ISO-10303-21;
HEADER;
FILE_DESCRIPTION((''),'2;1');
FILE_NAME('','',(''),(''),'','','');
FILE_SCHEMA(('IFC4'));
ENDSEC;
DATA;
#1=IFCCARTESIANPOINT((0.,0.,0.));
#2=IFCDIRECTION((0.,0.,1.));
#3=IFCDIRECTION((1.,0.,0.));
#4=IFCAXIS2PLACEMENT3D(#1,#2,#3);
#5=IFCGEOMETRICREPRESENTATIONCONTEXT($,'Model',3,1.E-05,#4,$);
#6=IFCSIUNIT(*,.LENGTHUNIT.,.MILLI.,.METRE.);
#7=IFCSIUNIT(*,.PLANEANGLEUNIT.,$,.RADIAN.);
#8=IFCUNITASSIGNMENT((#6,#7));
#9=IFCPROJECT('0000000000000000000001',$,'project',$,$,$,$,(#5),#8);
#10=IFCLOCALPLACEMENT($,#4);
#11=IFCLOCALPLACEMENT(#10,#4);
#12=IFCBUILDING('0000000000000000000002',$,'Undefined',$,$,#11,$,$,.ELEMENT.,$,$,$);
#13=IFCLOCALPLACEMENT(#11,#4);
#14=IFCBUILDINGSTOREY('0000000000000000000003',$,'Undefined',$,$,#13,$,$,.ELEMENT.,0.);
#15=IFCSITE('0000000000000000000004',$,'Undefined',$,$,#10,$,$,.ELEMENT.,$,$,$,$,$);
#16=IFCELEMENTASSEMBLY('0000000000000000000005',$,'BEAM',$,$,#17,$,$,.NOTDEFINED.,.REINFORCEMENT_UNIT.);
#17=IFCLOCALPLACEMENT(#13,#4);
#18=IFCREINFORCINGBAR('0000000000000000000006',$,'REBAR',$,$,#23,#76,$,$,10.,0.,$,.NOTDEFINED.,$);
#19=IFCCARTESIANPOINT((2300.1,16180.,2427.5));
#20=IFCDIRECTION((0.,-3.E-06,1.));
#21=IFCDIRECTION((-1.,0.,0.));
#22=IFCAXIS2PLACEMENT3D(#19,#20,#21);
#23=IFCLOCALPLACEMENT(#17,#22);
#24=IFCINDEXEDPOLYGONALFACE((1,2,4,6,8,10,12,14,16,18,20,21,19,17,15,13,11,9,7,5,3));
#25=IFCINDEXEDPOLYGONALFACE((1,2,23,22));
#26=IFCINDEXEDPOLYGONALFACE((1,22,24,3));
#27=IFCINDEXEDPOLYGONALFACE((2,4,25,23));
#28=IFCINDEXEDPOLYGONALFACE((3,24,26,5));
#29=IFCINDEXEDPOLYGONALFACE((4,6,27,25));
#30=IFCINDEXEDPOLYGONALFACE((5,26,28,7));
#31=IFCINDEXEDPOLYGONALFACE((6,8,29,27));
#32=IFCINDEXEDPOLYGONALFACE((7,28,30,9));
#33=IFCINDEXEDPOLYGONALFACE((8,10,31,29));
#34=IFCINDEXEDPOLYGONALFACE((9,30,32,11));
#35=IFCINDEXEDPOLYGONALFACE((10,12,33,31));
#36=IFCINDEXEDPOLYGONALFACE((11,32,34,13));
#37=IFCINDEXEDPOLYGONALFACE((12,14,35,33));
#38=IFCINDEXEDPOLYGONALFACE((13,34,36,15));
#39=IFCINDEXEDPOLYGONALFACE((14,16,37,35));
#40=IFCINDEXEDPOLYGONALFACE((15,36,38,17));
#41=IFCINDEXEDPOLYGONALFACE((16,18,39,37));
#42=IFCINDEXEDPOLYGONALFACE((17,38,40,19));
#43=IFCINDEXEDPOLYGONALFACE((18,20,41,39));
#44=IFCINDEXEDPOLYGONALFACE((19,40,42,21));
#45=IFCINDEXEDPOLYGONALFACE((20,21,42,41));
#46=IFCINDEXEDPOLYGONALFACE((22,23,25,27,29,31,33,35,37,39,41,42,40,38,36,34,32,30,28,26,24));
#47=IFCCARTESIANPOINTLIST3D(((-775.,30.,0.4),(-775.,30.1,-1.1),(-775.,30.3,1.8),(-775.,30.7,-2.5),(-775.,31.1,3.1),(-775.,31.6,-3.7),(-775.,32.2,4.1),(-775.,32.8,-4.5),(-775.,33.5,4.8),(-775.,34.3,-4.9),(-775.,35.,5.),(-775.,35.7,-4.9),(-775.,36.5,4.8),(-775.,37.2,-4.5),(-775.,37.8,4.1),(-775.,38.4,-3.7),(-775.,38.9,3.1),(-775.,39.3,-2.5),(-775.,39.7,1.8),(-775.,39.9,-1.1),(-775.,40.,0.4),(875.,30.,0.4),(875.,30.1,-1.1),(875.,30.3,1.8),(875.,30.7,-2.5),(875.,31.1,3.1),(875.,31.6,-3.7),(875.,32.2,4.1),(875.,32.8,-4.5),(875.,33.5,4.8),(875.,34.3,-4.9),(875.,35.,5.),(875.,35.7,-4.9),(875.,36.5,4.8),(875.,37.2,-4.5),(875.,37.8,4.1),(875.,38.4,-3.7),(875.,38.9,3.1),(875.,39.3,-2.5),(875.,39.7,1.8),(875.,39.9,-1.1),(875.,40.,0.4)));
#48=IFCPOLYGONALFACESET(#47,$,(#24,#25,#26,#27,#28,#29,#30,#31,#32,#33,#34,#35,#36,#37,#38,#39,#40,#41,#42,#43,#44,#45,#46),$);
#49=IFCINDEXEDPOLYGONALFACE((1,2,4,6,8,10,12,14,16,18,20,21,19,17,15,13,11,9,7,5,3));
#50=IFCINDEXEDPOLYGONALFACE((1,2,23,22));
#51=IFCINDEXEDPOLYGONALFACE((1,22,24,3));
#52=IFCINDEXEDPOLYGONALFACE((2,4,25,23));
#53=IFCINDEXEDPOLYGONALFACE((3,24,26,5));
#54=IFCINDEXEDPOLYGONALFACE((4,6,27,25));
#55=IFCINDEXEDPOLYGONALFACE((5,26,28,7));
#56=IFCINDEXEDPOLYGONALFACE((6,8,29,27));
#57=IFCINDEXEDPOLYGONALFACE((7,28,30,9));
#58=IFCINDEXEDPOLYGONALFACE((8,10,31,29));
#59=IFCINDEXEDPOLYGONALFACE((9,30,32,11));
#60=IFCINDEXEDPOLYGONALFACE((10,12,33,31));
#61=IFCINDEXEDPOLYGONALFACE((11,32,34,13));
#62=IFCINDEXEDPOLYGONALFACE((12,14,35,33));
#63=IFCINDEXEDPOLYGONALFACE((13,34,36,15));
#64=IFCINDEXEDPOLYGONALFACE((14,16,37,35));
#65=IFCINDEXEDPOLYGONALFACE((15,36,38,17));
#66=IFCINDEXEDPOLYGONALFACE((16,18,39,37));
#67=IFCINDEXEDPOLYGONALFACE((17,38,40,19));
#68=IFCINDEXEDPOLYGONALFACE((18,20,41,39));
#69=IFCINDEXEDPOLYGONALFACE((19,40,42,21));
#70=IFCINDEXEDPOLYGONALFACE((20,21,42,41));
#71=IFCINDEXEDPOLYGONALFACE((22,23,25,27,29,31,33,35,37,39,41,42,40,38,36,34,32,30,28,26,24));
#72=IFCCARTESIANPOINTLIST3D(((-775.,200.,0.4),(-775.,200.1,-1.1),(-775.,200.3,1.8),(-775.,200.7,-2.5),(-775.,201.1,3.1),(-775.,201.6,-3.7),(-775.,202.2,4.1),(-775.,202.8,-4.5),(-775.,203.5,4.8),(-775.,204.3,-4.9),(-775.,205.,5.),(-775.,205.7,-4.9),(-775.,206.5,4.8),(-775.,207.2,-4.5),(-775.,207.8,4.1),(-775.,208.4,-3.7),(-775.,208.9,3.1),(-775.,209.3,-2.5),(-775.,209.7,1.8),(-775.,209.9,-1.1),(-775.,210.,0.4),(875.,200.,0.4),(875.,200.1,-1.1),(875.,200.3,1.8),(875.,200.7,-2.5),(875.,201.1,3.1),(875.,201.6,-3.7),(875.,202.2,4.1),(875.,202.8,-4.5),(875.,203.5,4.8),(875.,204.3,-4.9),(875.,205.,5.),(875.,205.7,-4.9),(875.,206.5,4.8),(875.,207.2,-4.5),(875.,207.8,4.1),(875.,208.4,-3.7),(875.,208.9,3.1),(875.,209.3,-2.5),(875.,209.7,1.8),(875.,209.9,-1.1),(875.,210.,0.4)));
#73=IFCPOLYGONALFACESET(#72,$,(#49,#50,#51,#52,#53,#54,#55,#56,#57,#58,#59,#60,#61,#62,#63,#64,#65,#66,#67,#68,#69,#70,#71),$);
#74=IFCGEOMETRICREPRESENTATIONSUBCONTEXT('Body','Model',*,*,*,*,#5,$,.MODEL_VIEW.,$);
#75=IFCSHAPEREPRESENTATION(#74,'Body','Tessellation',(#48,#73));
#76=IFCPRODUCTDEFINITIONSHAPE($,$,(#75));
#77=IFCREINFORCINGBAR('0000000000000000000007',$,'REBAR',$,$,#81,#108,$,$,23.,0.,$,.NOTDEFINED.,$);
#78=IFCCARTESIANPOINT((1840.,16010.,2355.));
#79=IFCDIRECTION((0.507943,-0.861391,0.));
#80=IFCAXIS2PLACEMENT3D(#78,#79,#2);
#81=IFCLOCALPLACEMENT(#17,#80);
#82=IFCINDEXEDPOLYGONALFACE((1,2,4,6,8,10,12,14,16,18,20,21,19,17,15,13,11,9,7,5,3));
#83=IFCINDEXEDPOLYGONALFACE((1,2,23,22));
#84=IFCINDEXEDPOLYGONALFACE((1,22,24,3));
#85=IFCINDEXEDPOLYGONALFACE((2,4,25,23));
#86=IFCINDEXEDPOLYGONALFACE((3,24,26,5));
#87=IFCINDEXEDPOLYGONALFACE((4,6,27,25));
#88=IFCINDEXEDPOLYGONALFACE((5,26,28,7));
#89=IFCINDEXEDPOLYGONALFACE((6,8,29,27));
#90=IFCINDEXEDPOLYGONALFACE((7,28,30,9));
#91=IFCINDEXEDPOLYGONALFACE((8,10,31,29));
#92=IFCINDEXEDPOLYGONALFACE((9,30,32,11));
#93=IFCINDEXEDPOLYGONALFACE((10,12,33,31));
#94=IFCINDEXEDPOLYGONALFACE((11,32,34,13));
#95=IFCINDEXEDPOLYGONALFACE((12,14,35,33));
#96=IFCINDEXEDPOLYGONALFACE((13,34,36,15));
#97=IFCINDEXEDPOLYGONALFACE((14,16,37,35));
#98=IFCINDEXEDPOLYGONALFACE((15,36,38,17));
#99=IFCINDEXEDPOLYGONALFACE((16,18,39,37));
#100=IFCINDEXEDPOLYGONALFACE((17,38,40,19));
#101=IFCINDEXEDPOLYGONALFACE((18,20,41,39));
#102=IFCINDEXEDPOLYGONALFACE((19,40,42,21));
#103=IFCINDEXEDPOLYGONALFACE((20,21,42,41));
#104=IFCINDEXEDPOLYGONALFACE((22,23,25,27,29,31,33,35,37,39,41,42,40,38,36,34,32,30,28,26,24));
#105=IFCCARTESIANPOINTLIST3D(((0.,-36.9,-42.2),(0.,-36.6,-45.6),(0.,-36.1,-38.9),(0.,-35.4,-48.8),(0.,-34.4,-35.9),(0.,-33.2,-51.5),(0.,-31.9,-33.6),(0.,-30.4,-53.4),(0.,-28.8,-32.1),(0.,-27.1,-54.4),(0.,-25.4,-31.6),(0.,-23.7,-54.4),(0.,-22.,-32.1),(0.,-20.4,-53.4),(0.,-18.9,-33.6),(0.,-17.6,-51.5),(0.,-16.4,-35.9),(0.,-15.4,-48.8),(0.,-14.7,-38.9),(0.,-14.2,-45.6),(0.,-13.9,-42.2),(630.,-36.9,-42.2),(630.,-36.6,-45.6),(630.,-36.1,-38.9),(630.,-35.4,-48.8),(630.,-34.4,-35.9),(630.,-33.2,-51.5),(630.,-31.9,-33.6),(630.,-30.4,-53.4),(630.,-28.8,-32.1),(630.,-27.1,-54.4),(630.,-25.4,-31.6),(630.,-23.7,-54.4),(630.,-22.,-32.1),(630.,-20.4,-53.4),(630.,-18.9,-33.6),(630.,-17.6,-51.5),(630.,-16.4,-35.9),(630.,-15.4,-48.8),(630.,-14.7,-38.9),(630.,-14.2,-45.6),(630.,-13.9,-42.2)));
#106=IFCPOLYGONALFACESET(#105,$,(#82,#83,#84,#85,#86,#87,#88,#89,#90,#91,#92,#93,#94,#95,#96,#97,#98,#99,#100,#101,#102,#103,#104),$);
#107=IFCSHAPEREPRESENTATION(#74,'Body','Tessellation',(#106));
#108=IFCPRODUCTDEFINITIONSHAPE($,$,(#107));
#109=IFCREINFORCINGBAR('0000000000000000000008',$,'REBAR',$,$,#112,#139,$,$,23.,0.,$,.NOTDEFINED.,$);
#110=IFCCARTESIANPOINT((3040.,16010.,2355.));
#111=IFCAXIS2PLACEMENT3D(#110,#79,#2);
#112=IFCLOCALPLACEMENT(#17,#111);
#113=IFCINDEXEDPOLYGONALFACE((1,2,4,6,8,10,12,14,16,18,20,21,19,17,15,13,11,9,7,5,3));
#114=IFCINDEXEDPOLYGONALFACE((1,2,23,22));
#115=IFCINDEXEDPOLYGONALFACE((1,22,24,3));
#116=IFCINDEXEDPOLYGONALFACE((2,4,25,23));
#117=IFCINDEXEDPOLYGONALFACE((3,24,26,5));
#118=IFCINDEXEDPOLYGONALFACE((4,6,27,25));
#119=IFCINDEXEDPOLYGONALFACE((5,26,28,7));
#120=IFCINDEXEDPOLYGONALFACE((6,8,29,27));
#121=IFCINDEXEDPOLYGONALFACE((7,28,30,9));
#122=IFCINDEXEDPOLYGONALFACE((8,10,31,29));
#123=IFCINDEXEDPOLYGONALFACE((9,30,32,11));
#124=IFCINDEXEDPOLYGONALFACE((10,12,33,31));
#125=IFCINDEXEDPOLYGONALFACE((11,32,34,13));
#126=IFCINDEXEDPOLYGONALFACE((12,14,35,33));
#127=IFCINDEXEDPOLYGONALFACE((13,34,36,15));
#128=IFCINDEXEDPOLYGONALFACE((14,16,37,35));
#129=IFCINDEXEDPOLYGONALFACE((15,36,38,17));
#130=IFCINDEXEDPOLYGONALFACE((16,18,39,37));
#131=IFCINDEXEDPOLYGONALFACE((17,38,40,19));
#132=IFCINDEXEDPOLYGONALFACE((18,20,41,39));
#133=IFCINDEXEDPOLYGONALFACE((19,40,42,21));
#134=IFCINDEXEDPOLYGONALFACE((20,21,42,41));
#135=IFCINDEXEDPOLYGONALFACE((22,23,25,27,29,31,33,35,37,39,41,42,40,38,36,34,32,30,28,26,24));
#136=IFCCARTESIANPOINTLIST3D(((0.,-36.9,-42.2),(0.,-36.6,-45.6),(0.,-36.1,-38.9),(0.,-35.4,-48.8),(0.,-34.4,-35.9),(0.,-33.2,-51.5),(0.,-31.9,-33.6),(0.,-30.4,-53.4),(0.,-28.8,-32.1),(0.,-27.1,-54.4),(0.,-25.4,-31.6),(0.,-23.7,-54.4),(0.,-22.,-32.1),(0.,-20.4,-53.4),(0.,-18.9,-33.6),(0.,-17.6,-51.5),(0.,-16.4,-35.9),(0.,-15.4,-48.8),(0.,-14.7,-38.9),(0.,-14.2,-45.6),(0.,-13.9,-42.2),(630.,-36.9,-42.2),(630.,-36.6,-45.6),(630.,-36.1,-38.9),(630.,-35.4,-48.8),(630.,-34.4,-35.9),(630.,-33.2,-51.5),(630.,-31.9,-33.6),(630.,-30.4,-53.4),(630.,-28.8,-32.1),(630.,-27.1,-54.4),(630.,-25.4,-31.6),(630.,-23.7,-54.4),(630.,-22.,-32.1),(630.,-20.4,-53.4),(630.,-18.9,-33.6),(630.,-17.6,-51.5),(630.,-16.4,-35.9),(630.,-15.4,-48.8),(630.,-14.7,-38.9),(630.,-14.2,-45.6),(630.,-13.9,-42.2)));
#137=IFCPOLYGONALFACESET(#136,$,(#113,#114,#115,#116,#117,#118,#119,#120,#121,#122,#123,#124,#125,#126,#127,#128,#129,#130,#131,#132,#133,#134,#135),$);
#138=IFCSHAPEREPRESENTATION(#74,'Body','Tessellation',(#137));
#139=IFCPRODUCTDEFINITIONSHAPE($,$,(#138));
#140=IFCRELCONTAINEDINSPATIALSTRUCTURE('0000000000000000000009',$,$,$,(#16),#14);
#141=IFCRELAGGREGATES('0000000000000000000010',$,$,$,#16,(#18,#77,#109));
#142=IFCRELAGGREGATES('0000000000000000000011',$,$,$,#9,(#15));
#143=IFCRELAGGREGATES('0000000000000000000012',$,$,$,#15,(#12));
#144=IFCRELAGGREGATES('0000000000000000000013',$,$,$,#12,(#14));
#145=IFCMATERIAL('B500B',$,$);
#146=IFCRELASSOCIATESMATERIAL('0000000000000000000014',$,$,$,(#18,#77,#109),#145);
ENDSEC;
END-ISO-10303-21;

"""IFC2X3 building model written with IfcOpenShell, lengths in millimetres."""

from ifc_helpers import new_model, entity, si_unit, frame, origin_with_axes, place, context, subcontext, project, spatial, source, transform, mapped, material, element, aggregate, save


model = new_model("IFC2X3")

# Units and contexts
model_context = context("Model", 3, precision=1e-05, world=origin_with_axes())
body_context = subcontext(model_context, "Body", "Model", "MODEL_VIEW")
ifc_project = project(units=[si_unit("LENGTHUNIT", "METRE", prefix="MILLI"), si_unit("PLANEANGLEUNIT", "RADIAN")], contexts=[model_context])

# Site, building, storey
site_placement = place(None, origin_with_axes())
site = spatial("IfcSite", under=ifc_project, at=site_placement, Name="Undefined", CompositionType="ELEMENT")
building_placement = place(site_placement, origin_with_axes())
building = spatial("IfcBuilding", under=site, at=building_placement, Name="Undefined", CompositionType="ELEMENT")
storey_placement = place(building_placement, origin_with_axes())
storey = spatial("IfcBuildingStorey", under=building, at=storey_placement, Name="Undefined", CompositionType="ELEMENT", Elevation=0.0)

# Element assembly
assembly_1_placement = place(storey_placement, origin_with_axes())
assembly_1 = element("IfcElementAssembly", 1, at=assembly_1_placement, inside=storey, Name="BEAM", AssemblyPlace="NOTDEFINED", PredefinedType="REINFORCEMENT_UNIT")

# Reinforcing bars
ifc_material_1 = material(Name="B500B")
shared_shape_1 = source(origin_with_axes(), body_context, "Body", "AdvancedSweptSolid", [
    entity("IfcSweptDiskSolid", entity("IfcTrimmedCurve", entity("IfcLine", entity("IfcCartesianPoint", [0.0, 0.0, 0.0]), entity("IfcVector", entity("IfcDirection", [1.0, 0.0, 0.0]), 1.0)), [entity("IfcParameterValue", 0.0)], [entity("IfcParameterValue", 1649.999613)], True, "PARAMETER"), 5.0, None, 0.0, 1650.0),
])
shared_shape_2 = source(origin_with_axes(), body_context, "Body", "AdvancedSweptSolid", [
    entity("IfcSweptDiskSolid", entity("IfcTrimmedCurve", entity("IfcLine", entity("IfcCartesianPoint", [0.0, 0.0, 0.0]), entity("IfcVector", entity("IfcDirection", [1.0, 0.0, 0.0]), 1.0)), [entity("IfcParameterValue", 0.0)], [entity("IfcParameterValue", 1649.999613)], True, "PARAMETER"), 5.0, None, 0.0, 1650.0),
])
reinforcing_bar_1_placement = place(assembly_1_placement, frame((2300.1, 16180.0, 2427.5), z_axis=(0.0, -0.000003, 1.0), x_axis=(-1.0, 0.0, 0.0)))
reinforcing_bar_1 = element("IfcReinforcingBar", 2, at=reinforcing_bar_1_placement, material=ifc_material_1, Name="REBAR", BarRole="NOTDEFINED", CrossSectionArea=0.0, NominalDiameter=10.0, context=body_context, shape_type="MappedRepresentation", body=[
    mapped(shared_shape_1, transform((-775.0, 35.0, 0.0))),
    mapped(shared_shape_2, transform((-775.0, 205.0, 0.0))),
])
shared_shape_3 = source(origin_with_axes(), body_context, "Body", "AdvancedSweptSolid", [
    entity("IfcSweptDiskSolid", entity("IfcTrimmedCurve", entity("IfcLine", entity("IfcCartesianPoint", [0.0, 0.0, 0.0]), entity("IfcVector", entity("IfcDirection", [1.0, 0.0, 0.0]), 1.0)), [entity("IfcParameterValue", 0.0)], [entity("IfcParameterValue", 630.0)], True, "PARAMETER"), 11.5, None, 0.0, 630.0),
])
reinforcing_bar_2_placement = place(assembly_1_placement, frame((1840.0, 16010.0, 2355.0), z_axis=(0.507943, -0.861391, 0.0), x_axis=(0.0, 0.0, 1.0)))
reinforcing_bar_2 = element("IfcReinforcingBar", 3, at=reinforcing_bar_2_placement, material=ifc_material_1, Name="REBAR", BarRole="NOTDEFINED", CrossSectionArea=0.0, NominalDiameter=23.0, context=body_context, shape_type="MappedRepresentation", body=[
    mapped(shared_shape_3, transform((0.0, -25.4, -43.1))),
])
shared_shape_4 = source(origin_with_axes(), body_context, "Body", "AdvancedSweptSolid", [
    entity("IfcSweptDiskSolid", entity("IfcTrimmedCurve", entity("IfcLine", entity("IfcCartesianPoint", [0.0, 0.0, 0.0]), entity("IfcVector", entity("IfcDirection", [1.0, 0.0, 0.0]), 1.0)), [entity("IfcParameterValue", 0.0)], [entity("IfcParameterValue", 630.0)], True, "PARAMETER"), 11.5, None, 0.0, 630.0),
])
reinforcing_bar_3_placement = place(assembly_1_placement, frame((3040.0, 16010.0, 2355.0), z_axis=(0.507943, -0.861391, 0.0), x_axis=(0.0, 0.0, 1.0)))
reinforcing_bar_3 = element("IfcReinforcingBar", 4, at=reinforcing_bar_3_placement, material=ifc_material_1, Name="REBAR", BarRole="NOTDEFINED", CrossSectionArea=0.0, NominalDiameter=23.0, context=body_context, shape_type="MappedRepresentation", body=[
    mapped(shared_shape_4, transform((0.0, -25.4, -43.1))),
])
aggregate(assembly_1, [reinforcing_bar_1, reinforcing_bar_2, reinforcing_bar_3])

save(model, "model.ifc")
